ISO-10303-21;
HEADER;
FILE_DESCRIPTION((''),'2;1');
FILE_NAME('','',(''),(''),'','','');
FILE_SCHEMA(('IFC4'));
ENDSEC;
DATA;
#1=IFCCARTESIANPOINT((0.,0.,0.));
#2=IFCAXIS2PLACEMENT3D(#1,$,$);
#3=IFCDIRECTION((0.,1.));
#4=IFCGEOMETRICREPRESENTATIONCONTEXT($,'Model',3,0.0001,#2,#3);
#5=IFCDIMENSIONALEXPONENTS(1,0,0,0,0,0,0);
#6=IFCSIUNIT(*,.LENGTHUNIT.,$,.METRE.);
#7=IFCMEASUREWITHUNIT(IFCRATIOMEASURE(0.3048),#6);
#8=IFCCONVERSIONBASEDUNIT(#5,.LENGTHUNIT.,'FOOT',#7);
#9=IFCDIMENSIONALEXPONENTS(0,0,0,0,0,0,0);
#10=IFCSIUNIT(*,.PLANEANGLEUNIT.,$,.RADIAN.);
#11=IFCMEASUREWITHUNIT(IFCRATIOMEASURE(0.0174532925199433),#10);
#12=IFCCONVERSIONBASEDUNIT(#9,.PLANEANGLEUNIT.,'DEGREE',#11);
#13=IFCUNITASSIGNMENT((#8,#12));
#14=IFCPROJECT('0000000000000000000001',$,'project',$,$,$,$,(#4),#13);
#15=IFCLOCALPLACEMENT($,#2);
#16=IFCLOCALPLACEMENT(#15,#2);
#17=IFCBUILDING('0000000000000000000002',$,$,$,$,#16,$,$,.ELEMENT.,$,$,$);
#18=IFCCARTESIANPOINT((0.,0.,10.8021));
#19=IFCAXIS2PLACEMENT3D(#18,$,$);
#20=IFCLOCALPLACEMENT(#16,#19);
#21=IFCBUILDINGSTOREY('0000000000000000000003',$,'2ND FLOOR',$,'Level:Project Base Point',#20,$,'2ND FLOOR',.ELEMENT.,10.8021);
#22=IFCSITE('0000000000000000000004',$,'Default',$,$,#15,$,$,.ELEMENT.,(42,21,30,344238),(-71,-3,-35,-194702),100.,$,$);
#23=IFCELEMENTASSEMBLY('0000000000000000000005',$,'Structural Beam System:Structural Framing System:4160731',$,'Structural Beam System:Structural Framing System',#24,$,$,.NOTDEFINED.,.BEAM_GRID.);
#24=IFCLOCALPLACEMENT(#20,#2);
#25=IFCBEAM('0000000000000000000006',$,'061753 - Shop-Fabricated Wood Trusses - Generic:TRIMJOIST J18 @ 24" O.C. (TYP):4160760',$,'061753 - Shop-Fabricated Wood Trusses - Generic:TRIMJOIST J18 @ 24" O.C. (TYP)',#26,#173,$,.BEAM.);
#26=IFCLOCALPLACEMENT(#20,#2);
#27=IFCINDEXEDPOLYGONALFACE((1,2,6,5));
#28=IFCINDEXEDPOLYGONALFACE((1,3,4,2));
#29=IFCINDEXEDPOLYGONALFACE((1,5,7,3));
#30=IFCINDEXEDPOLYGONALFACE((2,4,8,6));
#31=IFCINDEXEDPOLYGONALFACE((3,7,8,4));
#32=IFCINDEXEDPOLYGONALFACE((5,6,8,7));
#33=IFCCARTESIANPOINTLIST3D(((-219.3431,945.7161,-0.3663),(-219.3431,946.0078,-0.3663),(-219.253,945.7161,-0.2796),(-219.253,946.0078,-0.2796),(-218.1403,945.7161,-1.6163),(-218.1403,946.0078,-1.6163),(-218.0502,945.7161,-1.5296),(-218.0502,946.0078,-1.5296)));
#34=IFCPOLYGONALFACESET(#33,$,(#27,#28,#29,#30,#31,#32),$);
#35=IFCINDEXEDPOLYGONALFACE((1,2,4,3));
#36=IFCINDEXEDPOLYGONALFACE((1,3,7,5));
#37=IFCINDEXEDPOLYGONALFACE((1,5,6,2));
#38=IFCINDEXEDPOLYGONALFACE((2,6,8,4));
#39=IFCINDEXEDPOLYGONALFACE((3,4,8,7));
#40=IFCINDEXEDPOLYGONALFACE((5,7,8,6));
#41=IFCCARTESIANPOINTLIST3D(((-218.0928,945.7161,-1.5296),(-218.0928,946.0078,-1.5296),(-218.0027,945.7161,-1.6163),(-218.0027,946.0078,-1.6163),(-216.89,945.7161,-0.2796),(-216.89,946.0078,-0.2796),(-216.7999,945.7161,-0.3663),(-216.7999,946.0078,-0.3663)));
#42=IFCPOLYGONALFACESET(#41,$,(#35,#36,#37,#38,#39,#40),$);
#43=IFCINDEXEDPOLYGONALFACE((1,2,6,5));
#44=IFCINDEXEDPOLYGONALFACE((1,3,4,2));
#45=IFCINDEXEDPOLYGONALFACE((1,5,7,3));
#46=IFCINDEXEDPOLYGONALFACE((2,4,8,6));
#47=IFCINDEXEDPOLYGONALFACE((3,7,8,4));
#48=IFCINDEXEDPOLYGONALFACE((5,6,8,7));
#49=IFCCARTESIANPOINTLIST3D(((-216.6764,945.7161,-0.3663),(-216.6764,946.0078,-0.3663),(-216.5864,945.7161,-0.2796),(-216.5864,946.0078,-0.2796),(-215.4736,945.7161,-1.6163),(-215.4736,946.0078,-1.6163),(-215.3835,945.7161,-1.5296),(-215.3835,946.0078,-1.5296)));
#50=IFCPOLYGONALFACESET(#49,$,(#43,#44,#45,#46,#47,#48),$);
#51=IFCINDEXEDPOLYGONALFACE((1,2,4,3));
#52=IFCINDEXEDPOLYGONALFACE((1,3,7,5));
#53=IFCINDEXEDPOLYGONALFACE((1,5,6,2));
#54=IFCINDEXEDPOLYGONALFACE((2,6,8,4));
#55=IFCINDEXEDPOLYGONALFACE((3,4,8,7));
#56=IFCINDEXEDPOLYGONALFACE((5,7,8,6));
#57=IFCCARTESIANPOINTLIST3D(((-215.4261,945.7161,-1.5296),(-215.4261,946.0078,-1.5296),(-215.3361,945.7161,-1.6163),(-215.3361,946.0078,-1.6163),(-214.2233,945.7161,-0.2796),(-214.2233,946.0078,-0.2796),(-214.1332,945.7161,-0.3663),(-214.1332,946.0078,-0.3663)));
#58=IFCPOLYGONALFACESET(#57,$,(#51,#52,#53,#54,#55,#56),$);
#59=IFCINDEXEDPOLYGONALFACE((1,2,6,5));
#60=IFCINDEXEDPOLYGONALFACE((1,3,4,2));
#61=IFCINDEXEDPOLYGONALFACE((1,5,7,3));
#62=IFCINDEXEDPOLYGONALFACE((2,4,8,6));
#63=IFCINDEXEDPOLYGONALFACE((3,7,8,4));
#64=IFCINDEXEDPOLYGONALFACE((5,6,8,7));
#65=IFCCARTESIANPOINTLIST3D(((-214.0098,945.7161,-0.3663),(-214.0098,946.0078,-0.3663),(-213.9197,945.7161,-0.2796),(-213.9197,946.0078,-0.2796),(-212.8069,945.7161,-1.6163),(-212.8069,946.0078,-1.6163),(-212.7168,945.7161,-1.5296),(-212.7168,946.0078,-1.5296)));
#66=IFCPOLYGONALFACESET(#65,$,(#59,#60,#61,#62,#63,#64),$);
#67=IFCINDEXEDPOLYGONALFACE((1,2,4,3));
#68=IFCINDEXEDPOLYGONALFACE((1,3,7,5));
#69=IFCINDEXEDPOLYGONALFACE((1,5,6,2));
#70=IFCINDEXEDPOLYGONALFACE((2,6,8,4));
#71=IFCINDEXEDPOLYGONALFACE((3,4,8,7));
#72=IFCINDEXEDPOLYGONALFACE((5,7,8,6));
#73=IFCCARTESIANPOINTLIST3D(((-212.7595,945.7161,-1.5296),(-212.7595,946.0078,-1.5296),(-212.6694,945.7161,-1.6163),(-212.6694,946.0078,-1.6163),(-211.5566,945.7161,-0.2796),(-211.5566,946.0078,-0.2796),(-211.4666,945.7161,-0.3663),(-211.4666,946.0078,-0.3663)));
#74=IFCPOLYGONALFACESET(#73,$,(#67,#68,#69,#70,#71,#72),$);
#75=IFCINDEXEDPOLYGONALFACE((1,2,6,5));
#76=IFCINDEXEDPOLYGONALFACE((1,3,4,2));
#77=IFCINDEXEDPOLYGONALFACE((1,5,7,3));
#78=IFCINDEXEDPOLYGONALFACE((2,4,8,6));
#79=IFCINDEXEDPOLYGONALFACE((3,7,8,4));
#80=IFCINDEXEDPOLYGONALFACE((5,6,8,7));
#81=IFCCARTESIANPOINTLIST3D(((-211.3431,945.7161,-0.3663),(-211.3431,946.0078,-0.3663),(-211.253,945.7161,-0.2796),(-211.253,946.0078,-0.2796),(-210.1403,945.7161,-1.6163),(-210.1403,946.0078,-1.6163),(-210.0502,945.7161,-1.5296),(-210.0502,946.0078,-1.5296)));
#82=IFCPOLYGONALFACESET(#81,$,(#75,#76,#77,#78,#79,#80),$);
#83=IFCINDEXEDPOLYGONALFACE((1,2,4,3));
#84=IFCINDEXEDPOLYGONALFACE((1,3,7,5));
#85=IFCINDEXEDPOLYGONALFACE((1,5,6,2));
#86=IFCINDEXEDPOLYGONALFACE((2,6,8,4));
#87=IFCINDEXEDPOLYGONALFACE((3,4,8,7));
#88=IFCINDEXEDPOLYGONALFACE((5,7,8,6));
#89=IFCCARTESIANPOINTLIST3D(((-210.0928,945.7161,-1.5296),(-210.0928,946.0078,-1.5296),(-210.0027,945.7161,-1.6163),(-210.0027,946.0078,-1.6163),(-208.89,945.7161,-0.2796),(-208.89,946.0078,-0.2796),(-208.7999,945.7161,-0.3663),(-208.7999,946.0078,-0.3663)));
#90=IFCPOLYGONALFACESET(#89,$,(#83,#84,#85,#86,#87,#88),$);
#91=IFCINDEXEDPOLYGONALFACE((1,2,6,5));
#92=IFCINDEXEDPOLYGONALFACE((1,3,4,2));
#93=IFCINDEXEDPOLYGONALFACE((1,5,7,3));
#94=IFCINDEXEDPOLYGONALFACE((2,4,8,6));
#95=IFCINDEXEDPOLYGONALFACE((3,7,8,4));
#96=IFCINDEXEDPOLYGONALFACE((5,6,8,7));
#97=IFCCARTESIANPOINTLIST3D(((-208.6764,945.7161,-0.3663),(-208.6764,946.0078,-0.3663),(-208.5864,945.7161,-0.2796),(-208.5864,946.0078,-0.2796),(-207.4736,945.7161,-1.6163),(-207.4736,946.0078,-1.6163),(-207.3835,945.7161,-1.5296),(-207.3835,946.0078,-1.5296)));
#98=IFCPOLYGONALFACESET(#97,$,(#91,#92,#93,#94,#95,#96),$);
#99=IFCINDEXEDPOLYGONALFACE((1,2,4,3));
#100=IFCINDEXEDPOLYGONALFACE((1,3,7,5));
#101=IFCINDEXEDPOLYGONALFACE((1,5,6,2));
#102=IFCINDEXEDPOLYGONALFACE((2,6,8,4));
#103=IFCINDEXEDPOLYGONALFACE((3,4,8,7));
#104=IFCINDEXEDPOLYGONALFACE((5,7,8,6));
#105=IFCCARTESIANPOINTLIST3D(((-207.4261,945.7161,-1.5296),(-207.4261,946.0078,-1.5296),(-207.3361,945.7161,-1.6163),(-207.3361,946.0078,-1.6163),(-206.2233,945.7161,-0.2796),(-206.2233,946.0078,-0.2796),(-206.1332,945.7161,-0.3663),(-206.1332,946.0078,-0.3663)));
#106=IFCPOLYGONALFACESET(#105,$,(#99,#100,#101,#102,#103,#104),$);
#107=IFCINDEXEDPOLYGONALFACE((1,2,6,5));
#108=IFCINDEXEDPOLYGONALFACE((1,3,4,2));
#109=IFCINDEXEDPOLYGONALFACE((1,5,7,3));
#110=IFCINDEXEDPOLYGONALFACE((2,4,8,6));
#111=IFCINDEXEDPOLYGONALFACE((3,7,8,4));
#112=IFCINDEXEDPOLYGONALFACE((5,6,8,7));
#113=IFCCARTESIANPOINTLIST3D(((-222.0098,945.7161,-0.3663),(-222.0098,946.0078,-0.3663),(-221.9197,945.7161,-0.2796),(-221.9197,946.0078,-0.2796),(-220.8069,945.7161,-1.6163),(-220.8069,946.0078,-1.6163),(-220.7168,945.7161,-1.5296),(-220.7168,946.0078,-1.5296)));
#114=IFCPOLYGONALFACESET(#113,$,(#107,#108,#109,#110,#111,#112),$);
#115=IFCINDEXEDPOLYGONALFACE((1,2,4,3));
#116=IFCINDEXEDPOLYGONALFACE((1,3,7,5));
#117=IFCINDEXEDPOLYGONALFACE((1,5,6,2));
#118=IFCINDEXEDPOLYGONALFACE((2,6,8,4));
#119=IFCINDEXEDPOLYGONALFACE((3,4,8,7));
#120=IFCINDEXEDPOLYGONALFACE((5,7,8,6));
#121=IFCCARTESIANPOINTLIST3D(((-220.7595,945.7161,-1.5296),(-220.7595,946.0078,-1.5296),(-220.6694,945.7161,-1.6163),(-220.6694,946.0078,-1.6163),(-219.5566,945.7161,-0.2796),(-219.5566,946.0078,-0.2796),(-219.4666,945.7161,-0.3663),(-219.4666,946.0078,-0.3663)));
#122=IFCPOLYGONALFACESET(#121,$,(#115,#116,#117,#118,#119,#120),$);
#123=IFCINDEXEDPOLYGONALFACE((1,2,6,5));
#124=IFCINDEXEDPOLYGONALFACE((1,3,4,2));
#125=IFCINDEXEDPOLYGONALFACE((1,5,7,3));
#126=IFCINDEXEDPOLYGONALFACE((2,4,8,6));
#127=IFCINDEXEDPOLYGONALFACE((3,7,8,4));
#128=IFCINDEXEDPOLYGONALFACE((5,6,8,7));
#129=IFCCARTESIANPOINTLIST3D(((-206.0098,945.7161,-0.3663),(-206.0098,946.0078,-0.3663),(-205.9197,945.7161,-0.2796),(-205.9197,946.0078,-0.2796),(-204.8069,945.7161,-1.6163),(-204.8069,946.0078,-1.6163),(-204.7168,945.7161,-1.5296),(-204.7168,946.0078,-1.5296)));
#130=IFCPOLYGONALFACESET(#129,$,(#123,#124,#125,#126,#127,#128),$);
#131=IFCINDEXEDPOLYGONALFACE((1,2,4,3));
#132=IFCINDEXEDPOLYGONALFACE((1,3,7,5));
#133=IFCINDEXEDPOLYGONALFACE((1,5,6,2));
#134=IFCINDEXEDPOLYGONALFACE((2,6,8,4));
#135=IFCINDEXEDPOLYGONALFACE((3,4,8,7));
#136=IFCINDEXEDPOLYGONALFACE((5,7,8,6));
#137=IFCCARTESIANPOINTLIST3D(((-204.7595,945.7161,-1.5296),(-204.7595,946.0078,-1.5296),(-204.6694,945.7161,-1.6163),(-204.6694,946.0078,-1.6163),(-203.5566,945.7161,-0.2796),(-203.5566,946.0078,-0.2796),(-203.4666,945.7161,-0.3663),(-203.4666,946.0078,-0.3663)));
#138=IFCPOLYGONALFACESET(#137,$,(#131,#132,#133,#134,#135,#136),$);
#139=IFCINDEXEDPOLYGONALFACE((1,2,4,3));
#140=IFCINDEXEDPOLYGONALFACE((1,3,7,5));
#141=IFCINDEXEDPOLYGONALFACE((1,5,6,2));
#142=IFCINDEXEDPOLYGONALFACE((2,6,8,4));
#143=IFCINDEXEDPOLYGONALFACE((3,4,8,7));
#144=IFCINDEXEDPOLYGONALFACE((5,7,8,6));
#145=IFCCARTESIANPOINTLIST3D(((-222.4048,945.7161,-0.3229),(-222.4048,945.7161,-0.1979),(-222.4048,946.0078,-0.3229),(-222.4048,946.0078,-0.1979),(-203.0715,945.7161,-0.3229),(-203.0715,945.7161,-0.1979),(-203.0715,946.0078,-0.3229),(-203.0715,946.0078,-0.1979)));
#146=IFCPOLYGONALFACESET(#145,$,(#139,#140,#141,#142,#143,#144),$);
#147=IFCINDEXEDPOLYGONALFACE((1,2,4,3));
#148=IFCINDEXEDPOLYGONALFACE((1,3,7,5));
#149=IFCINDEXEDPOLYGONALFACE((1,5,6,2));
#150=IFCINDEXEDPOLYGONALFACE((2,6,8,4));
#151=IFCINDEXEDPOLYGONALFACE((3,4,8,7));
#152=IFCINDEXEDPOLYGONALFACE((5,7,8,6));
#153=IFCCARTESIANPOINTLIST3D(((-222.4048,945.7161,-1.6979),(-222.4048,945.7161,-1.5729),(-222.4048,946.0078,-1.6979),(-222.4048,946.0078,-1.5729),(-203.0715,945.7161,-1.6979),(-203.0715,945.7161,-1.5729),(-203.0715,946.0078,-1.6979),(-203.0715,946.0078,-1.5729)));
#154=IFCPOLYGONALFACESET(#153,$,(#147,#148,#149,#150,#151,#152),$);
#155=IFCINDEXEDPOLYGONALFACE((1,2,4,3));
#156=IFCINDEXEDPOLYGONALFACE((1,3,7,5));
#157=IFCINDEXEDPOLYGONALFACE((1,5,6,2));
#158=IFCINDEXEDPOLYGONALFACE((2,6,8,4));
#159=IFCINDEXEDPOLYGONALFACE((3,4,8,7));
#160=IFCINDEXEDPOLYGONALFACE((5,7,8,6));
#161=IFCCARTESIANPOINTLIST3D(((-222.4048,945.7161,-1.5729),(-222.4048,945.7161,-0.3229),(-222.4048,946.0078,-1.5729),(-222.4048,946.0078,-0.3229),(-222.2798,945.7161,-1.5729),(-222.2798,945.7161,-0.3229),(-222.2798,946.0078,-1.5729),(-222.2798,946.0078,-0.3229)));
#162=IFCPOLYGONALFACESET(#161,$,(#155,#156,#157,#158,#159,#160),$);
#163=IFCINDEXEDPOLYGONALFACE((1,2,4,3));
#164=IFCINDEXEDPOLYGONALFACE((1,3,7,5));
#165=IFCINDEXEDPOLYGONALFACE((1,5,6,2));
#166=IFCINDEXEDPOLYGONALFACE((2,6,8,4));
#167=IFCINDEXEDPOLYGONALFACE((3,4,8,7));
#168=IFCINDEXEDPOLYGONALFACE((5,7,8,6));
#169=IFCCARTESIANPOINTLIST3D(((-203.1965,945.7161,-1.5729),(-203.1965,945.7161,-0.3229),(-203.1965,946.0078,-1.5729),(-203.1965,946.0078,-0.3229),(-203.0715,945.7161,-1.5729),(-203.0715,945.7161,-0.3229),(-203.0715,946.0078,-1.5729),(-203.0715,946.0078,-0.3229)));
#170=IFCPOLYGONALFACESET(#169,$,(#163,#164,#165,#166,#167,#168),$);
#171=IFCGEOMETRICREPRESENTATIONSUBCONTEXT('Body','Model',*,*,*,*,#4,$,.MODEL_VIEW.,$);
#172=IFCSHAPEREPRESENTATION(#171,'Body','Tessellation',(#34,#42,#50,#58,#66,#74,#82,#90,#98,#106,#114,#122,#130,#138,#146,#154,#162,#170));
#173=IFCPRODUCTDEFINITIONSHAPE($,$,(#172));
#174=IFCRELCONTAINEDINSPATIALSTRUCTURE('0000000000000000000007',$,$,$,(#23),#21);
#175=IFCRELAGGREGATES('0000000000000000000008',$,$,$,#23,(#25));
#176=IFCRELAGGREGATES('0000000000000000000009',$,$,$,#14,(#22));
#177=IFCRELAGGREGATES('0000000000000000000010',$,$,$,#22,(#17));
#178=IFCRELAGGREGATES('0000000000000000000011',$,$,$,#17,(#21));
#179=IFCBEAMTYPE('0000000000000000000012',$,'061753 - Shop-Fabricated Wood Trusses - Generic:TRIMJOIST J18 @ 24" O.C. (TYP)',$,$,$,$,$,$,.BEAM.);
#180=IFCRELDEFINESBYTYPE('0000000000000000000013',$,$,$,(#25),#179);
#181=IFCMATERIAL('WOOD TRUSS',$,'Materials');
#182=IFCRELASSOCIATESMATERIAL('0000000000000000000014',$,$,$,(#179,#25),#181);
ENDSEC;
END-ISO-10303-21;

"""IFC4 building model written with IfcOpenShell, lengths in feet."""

from ifc_helpers import new_model, entity, si_unit, converted_unit, direction, frame, frame_2d, origin, origin_2d_with_axis, place, context, subcontext, project, spatial, rectangle, extrude, source, transform, mapped, material, material_profile, profile_set, profile_usage, type_object, type_shapes, element, aggregate, save


model = new_model("IFC4")

# Units and contexts
model_context = context("Model", 3, precision=0.0001, world=origin(), true_north=direction((0.0, 1.0)))
body_context = subcontext(model_context, "Body", "Model", "MODEL_VIEW")
ifc_project = project(units=[converted_unit("LENGTHUNIT", "FOOT", entity("IfcRatioMeasure", 0.3048), si_unit("LENGTHUNIT", "METRE"), dimensions=[1, 0, 0, 0, 0, 0, 0]), converted_unit("PLANEANGLEUNIT", "DEGREE", entity("IfcRatioMeasure", 0.0174532925199433), si_unit("PLANEANGLEUNIT", "RADIAN"), dimensions=[0, 0, 0, 0, 0, 0, 0])], contexts=[model_context])

# Site, building, storey
site_placement = place(None, origin())
site = spatial("IfcSite", under=ifc_project, at=site_placement, Name="Default", CompositionType="ELEMENT", RefLatitude=(42, 21, 30, 344238), RefLongitude=(-71, -3, -35, -194702), RefElevation=100.0)
building_placement = place(site_placement, origin())
building = spatial("IfcBuilding", under=site, at=building_placement, CompositionType="ELEMENT")
storey_placement = place(building_placement, frame((0.0, 0.0, 10.8021)))
storey = spatial("IfcBuildingStorey", under=building, at=storey_placement, Name="2ND FLOOR", ObjectType="Level:Project Base Point", LongName="2ND FLOOR", CompositionType="ELEMENT", Elevation=10.8021)

# Element assembly, beam
ifc_material_1 = material(Name="WOOD TRUSS", Category="Materials")
ifc_material_profile_1 = material_profile(ifc_material_1, rectangle(XDim=1.7347, YDim=0.125, at=frame_2d((0.0, 0.0), x_axis=(1.0, 0.0))), Name="TRIMJOIST J18 @ 24\" O.C. (TYP)")
ifc_material_profile_2 = material_profile(ifc_material_1, rectangle(XDim=1.7347, YDim=0.125, at=frame_2d((0.0, 0.0), x_axis=(1.0, 0.0))), Name="TRIMJOIST J18 @ 24\" O.C. (TYP)")
ifc_material_profile_3 = material_profile(ifc_material_1, rectangle(XDim=1.7347, YDim=0.125, at=frame_2d((0.0, 0.0), x_axis=(1.0, 0.0))), Name="TRIMJOIST J18 @ 24\" O.C. (TYP)")
ifc_material_profile_4 = material_profile(ifc_material_1, rectangle(XDim=1.7347, YDim=0.125, at=frame_2d((0.0, 0.0), x_axis=(1.0, 0.0))), Name="TRIMJOIST J18 @ 24\" O.C. (TYP)")
ifc_material_profile_5 = material_profile(ifc_material_1, rectangle(XDim=1.7347, YDim=0.125, at=frame_2d((0.0, 0.0), x_axis=(1.0, 0.0))), Name="TRIMJOIST J18 @ 24\" O.C. (TYP)")
ifc_material_profile_6 = material_profile(ifc_material_1, rectangle(XDim=1.7347, YDim=0.125, at=frame_2d((0.0, 0.0), x_axis=(1.0, 0.0))), Name="TRIMJOIST J18 @ 24\" O.C. (TYP)")
ifc_material_profile_7 = material_profile(ifc_material_1, rectangle(XDim=1.7347, YDim=0.125, at=frame_2d((0.0, 0.0), x_axis=(1.0, 0.0))), Name="TRIMJOIST J18 @ 24\" O.C. (TYP)")
ifc_material_profile_8 = material_profile(ifc_material_1, rectangle(XDim=1.7347, YDim=0.125, at=frame_2d((0.0, 0.0), x_axis=(1.0, 0.0))), Name="TRIMJOIST J18 @ 24\" O.C. (TYP)")
ifc_material_profile_9 = material_profile(ifc_material_1, rectangle(XDim=1.7347, YDim=0.125, at=frame_2d((0.0, 0.0), x_axis=(1.0, 0.0))), Name="TRIMJOIST J18 @ 24\" O.C. (TYP)")
ifc_material_profile_10 = material_profile(ifc_material_1, rectangle(XDim=1.7347, YDim=0.125, at=origin_2d_with_axis()), Name="TRIMJOIST J18 @ 24\" O.C. (TYP)")
ifc_material_profile_11 = material_profile(ifc_material_1, rectangle(XDim=0.125, YDim=0.2917, at=origin_2d_with_axis()), Name="TRIMJOIST J18 @ 24\" O.C. (TYP)")
ifc_material_profile_12 = material_profile(ifc_material_1, rectangle(XDim=0.125, YDim=0.2917, at=origin_2d_with_axis()), Name="TRIMJOIST J18 @ 24\" O.C. (TYP)")
ifc_material_profile_13 = material_profile(ifc_material_1, rectangle(XDim=1.25, YDim=0.2917, at=origin_2d_with_axis()), Name="TRIMJOIST J18 @ 24\" O.C. (TYP)")
ifc_material_profile_14 = material_profile(ifc_material_1, rectangle(XDim=1.25, YDim=0.2917, at=origin_2d_with_axis()), Name="TRIMJOIST J18 @ 24\" O.C. (TYP)")
ifc_profile_set_1 = profile_set([ifc_material_profile_1, ifc_material_profile_2, ifc_material_profile_3, ifc_material_profile_4, ifc_material_profile_5, ifc_material_profile_6, ifc_material_profile_7, ifc_material_profile_8, ifc_material_profile_9, ifc_material_profile_10, ifc_material_profile_11, ifc_material_profile_12, ifc_material_profile_13, ifc_material_profile_14], Name="TRIMJOIST J18 @ 24\" O.C. (TYP)")
beam_type_1 = type_object("IfcBeamType", Name="061753 - Shop-Fabricated Wood Trusses - Generic:TRIMJOIST J18 @ 24\" O.C. (TYP)", PredefinedType="BEAM", material=ifc_profile_set_1)
shared_shape_1 = source(origin(), body_context, "Body", "SweptSolid", [
    extrude(rectangle(XDim=1.7347, YDim=0.125, at=frame_2d((0.0, 0.0), x_axis=(1.0, 0.0))), frame((5.9585, -0.1458, 0.0), z_axis=(0.0, 1.0, 0.0), x_axis=(0.693383, 0.0, 0.720569)), (0.0, 0.0, 1.0), 0.2917),
    extrude(rectangle(XDim=1.7347, YDim=0.125, at=origin_2d_with_axis()), frame((4.7082, -0.1458, 0.0), z_axis=(0.0, 1.0, 0.0), x_axis=(0.693383, 0.0, -0.720569)), (0.0, 0.0, 1.0), 0.2917),
    extrude(rectangle(XDim=1.7347, YDim=0.125, at=frame_2d((0.0, 0.0), x_axis=(1.0, 0.0))), frame((3.2918, -0.1458, 0.0), z_axis=(0.0, 1.0, 0.0), x_axis=(0.693383, 0.0, 0.720569)), (0.0, 0.0, 1.0), 0.2917),
    extrude(rectangle(XDim=1.7347, YDim=0.125, at=frame_2d((0.0, 0.0), x_axis=(1.0, 0.0))), frame((2.0415, -0.1458, 0.0), z_axis=(0.0, 1.0, 0.0), x_axis=(0.693383, 0.0, -0.720569)), (0.0, 0.0, 1.0), 0.2917),
    extrude(rectangle(XDim=1.7347, YDim=0.125, at=frame_2d((0.0, 0.0), x_axis=(1.0, 0.0))), frame((0.6251, -0.1458, 0.0), z_axis=(0.0, 1.0, 0.0), x_axis=(0.693383, 0.0, 0.720569)), (0.0, 0.0, 1.0), 0.2917),
    extrude(rectangle(XDim=1.7347, YDim=0.125, at=frame_2d((0.0, 0.0), x_axis=(1.0, 0.0))), frame((-0.6251, -0.1458, 0.0), z_axis=(0.0, 1.0, 0.0), x_axis=(0.693383, 0.0, -0.720569)), (0.0, 0.0, 1.0), 0.2917),
    extrude(rectangle(XDim=1.7347, YDim=0.125, at=frame_2d((0.0, 0.0), x_axis=(1.0, 0.0))), frame((-2.0415, -0.1458, 0.0), z_axis=(0.0, 1.0, 0.0), x_axis=(0.693383, 0.0, 0.720569)), (0.0, 0.0, 1.0), 0.2917),
    extrude(rectangle(XDim=1.7347, YDim=0.125, at=origin_2d_with_axis()), frame((-3.2918, -0.1458, 0.0), z_axis=(0.0, 1.0, 0.0), x_axis=(0.693383, 0.0, -0.720569)), (0.0, 0.0, 1.0), 0.2917),
    extrude(rectangle(XDim=1.7347, YDim=0.125, at=frame_2d((0.0, 0.0), x_axis=(1.0, 0.0))), frame((-4.7082, -0.1458, 0.0), z_axis=(0.0, 1.0, 0.0), x_axis=(0.693383, 0.0, 0.720569)), (0.0, 0.0, 1.0), 0.2917),
    extrude(rectangle(XDim=1.7347, YDim=0.125, at=frame_2d((0.0, 0.0), x_axis=(1.0, 0.0))), frame((-5.9585, -0.1458, 0.0), z_axis=(0.0, 1.0, 0.0), x_axis=(0.693383, 0.0, -0.720569)), (0.0, 0.0, 1.0), 0.2917),
    extrude(rectangle(XDim=1.7347, YDim=0.125, at=frame_2d((0.0, 0.0), x_axis=(1.0, 0.0))), frame((8.6251, -0.1458, 0.0), z_axis=(0.0, 1.0, 0.0), x_axis=(0.693383, 0.0, 0.720569)), (0.0, 0.0, 1.0), 0.2917),
    extrude(rectangle(XDim=1.7347, YDim=0.125, at=origin_2d_with_axis()), frame((7.3749, -0.1458, 0.0), z_axis=(0.0, 1.0, 0.0), x_axis=(0.693383, 0.0, -0.720569)), (0.0, 0.0, 1.0), 0.2917),
    extrude(rectangle(XDim=1.7347, YDim=0.125, at=frame_2d((0.0, 0.0), x_axis=(1.0, 0.0))), frame((-7.3749, -0.1458, 0.0), z_axis=(0.0, 1.0, 0.0), x_axis=(0.693383, 0.0, 0.720569)), (0.0, 0.0, 1.0), 0.2917),
    extrude(rectangle(XDim=1.7347, YDim=0.125, at=origin_2d_with_axis()), frame((-8.6251, -0.1458, 0.0), z_axis=(0.0, 1.0, 0.0), x_axis=(0.693383, 0.0, -0.720569)), (0.0, 0.0, 1.0), 0.2917),
    extrude(rectangle(XDim=0.125, YDim=0.2917, at=origin_2d_with_axis()), frame((-9.6667, 0.0, 0.6875), z_axis=(1.0, 0.0, 0.0), x_axis=(0.0, 0.0, -1.0)), (0.0, 0.0, 1.0), 19.3333),
    extrude(rectangle(XDim=0.125, YDim=0.2917, at=origin_2d_with_axis()), frame((-9.6667, 0.0, -0.6875), z_axis=(1.0, 0.0, 0.0), x_axis=(0.0, 0.0, -1.0)), (0.0, 0.0, 1.0), 19.3333),
    extrude(rectangle(XDim=1.25, YDim=0.2917, at=origin_2d_with_axis()), frame((9.5417, 0.0, 0.0), z_axis=(1.0, 0.0, 0.0), x_axis=(0.0, 0.0, -1.0)), (0.0, 0.0, 1.0), 0.125),
    extrude(rectangle(XDim=1.25, YDim=0.2917, at=origin_2d_with_axis()), frame((-9.6667, 0.0, 0.0), z_axis=(1.0, 0.0, 0.0), x_axis=(0.0, 0.0, -1.0)), (0.0, 0.0, 1.0), 0.125),
])
type_shapes(beam_type_1, [shared_shape_1])
assembly_1_placement = place(storey_placement, origin())
assembly_1 = element("IfcElementAssembly", 1, at=assembly_1_placement, inside=storey, Name="Structural Beam System:Structural Framing System:4160731", ObjectType="Structural Beam System:Structural Framing System", AssemblyPlace="NOTDEFINED", PredefinedType="BEAM_GRID")
ifc_profile_usage_1 = profile_usage(ifc_profile_set_1, cardinal=8)
beam_1_placement = place(assembly_1_placement, frame((-212.7382, 945.8619, -0.9479), z_axis=(0.0, 0.0, 1.0), x_axis=(-1.0, 0.0, 0.0)))
beam_1 = element("IfcBeam", 2, at=beam_1_placement, type_object=beam_type_1, material=ifc_profile_usage_1, Name="061753 - Shop-Fabricated Wood Trusses - Generic:TRIMJOIST J18 @ 24\" O.C. (TYP):4160760", ObjectType="061753 - Shop-Fabricated Wood Trusses - Generic:TRIMJOIST J18 @ 24\" O.C. (TYP)", PredefinedType="BEAM", context=body_context, shape_type="MappedRepresentation", body=[
    mapped(shared_shape_1, transform((0.0, 0.0, 0.0), scale=1.0)),
])
aggregate(assembly_1, [beam_1])

save(model, "model.ifc")
